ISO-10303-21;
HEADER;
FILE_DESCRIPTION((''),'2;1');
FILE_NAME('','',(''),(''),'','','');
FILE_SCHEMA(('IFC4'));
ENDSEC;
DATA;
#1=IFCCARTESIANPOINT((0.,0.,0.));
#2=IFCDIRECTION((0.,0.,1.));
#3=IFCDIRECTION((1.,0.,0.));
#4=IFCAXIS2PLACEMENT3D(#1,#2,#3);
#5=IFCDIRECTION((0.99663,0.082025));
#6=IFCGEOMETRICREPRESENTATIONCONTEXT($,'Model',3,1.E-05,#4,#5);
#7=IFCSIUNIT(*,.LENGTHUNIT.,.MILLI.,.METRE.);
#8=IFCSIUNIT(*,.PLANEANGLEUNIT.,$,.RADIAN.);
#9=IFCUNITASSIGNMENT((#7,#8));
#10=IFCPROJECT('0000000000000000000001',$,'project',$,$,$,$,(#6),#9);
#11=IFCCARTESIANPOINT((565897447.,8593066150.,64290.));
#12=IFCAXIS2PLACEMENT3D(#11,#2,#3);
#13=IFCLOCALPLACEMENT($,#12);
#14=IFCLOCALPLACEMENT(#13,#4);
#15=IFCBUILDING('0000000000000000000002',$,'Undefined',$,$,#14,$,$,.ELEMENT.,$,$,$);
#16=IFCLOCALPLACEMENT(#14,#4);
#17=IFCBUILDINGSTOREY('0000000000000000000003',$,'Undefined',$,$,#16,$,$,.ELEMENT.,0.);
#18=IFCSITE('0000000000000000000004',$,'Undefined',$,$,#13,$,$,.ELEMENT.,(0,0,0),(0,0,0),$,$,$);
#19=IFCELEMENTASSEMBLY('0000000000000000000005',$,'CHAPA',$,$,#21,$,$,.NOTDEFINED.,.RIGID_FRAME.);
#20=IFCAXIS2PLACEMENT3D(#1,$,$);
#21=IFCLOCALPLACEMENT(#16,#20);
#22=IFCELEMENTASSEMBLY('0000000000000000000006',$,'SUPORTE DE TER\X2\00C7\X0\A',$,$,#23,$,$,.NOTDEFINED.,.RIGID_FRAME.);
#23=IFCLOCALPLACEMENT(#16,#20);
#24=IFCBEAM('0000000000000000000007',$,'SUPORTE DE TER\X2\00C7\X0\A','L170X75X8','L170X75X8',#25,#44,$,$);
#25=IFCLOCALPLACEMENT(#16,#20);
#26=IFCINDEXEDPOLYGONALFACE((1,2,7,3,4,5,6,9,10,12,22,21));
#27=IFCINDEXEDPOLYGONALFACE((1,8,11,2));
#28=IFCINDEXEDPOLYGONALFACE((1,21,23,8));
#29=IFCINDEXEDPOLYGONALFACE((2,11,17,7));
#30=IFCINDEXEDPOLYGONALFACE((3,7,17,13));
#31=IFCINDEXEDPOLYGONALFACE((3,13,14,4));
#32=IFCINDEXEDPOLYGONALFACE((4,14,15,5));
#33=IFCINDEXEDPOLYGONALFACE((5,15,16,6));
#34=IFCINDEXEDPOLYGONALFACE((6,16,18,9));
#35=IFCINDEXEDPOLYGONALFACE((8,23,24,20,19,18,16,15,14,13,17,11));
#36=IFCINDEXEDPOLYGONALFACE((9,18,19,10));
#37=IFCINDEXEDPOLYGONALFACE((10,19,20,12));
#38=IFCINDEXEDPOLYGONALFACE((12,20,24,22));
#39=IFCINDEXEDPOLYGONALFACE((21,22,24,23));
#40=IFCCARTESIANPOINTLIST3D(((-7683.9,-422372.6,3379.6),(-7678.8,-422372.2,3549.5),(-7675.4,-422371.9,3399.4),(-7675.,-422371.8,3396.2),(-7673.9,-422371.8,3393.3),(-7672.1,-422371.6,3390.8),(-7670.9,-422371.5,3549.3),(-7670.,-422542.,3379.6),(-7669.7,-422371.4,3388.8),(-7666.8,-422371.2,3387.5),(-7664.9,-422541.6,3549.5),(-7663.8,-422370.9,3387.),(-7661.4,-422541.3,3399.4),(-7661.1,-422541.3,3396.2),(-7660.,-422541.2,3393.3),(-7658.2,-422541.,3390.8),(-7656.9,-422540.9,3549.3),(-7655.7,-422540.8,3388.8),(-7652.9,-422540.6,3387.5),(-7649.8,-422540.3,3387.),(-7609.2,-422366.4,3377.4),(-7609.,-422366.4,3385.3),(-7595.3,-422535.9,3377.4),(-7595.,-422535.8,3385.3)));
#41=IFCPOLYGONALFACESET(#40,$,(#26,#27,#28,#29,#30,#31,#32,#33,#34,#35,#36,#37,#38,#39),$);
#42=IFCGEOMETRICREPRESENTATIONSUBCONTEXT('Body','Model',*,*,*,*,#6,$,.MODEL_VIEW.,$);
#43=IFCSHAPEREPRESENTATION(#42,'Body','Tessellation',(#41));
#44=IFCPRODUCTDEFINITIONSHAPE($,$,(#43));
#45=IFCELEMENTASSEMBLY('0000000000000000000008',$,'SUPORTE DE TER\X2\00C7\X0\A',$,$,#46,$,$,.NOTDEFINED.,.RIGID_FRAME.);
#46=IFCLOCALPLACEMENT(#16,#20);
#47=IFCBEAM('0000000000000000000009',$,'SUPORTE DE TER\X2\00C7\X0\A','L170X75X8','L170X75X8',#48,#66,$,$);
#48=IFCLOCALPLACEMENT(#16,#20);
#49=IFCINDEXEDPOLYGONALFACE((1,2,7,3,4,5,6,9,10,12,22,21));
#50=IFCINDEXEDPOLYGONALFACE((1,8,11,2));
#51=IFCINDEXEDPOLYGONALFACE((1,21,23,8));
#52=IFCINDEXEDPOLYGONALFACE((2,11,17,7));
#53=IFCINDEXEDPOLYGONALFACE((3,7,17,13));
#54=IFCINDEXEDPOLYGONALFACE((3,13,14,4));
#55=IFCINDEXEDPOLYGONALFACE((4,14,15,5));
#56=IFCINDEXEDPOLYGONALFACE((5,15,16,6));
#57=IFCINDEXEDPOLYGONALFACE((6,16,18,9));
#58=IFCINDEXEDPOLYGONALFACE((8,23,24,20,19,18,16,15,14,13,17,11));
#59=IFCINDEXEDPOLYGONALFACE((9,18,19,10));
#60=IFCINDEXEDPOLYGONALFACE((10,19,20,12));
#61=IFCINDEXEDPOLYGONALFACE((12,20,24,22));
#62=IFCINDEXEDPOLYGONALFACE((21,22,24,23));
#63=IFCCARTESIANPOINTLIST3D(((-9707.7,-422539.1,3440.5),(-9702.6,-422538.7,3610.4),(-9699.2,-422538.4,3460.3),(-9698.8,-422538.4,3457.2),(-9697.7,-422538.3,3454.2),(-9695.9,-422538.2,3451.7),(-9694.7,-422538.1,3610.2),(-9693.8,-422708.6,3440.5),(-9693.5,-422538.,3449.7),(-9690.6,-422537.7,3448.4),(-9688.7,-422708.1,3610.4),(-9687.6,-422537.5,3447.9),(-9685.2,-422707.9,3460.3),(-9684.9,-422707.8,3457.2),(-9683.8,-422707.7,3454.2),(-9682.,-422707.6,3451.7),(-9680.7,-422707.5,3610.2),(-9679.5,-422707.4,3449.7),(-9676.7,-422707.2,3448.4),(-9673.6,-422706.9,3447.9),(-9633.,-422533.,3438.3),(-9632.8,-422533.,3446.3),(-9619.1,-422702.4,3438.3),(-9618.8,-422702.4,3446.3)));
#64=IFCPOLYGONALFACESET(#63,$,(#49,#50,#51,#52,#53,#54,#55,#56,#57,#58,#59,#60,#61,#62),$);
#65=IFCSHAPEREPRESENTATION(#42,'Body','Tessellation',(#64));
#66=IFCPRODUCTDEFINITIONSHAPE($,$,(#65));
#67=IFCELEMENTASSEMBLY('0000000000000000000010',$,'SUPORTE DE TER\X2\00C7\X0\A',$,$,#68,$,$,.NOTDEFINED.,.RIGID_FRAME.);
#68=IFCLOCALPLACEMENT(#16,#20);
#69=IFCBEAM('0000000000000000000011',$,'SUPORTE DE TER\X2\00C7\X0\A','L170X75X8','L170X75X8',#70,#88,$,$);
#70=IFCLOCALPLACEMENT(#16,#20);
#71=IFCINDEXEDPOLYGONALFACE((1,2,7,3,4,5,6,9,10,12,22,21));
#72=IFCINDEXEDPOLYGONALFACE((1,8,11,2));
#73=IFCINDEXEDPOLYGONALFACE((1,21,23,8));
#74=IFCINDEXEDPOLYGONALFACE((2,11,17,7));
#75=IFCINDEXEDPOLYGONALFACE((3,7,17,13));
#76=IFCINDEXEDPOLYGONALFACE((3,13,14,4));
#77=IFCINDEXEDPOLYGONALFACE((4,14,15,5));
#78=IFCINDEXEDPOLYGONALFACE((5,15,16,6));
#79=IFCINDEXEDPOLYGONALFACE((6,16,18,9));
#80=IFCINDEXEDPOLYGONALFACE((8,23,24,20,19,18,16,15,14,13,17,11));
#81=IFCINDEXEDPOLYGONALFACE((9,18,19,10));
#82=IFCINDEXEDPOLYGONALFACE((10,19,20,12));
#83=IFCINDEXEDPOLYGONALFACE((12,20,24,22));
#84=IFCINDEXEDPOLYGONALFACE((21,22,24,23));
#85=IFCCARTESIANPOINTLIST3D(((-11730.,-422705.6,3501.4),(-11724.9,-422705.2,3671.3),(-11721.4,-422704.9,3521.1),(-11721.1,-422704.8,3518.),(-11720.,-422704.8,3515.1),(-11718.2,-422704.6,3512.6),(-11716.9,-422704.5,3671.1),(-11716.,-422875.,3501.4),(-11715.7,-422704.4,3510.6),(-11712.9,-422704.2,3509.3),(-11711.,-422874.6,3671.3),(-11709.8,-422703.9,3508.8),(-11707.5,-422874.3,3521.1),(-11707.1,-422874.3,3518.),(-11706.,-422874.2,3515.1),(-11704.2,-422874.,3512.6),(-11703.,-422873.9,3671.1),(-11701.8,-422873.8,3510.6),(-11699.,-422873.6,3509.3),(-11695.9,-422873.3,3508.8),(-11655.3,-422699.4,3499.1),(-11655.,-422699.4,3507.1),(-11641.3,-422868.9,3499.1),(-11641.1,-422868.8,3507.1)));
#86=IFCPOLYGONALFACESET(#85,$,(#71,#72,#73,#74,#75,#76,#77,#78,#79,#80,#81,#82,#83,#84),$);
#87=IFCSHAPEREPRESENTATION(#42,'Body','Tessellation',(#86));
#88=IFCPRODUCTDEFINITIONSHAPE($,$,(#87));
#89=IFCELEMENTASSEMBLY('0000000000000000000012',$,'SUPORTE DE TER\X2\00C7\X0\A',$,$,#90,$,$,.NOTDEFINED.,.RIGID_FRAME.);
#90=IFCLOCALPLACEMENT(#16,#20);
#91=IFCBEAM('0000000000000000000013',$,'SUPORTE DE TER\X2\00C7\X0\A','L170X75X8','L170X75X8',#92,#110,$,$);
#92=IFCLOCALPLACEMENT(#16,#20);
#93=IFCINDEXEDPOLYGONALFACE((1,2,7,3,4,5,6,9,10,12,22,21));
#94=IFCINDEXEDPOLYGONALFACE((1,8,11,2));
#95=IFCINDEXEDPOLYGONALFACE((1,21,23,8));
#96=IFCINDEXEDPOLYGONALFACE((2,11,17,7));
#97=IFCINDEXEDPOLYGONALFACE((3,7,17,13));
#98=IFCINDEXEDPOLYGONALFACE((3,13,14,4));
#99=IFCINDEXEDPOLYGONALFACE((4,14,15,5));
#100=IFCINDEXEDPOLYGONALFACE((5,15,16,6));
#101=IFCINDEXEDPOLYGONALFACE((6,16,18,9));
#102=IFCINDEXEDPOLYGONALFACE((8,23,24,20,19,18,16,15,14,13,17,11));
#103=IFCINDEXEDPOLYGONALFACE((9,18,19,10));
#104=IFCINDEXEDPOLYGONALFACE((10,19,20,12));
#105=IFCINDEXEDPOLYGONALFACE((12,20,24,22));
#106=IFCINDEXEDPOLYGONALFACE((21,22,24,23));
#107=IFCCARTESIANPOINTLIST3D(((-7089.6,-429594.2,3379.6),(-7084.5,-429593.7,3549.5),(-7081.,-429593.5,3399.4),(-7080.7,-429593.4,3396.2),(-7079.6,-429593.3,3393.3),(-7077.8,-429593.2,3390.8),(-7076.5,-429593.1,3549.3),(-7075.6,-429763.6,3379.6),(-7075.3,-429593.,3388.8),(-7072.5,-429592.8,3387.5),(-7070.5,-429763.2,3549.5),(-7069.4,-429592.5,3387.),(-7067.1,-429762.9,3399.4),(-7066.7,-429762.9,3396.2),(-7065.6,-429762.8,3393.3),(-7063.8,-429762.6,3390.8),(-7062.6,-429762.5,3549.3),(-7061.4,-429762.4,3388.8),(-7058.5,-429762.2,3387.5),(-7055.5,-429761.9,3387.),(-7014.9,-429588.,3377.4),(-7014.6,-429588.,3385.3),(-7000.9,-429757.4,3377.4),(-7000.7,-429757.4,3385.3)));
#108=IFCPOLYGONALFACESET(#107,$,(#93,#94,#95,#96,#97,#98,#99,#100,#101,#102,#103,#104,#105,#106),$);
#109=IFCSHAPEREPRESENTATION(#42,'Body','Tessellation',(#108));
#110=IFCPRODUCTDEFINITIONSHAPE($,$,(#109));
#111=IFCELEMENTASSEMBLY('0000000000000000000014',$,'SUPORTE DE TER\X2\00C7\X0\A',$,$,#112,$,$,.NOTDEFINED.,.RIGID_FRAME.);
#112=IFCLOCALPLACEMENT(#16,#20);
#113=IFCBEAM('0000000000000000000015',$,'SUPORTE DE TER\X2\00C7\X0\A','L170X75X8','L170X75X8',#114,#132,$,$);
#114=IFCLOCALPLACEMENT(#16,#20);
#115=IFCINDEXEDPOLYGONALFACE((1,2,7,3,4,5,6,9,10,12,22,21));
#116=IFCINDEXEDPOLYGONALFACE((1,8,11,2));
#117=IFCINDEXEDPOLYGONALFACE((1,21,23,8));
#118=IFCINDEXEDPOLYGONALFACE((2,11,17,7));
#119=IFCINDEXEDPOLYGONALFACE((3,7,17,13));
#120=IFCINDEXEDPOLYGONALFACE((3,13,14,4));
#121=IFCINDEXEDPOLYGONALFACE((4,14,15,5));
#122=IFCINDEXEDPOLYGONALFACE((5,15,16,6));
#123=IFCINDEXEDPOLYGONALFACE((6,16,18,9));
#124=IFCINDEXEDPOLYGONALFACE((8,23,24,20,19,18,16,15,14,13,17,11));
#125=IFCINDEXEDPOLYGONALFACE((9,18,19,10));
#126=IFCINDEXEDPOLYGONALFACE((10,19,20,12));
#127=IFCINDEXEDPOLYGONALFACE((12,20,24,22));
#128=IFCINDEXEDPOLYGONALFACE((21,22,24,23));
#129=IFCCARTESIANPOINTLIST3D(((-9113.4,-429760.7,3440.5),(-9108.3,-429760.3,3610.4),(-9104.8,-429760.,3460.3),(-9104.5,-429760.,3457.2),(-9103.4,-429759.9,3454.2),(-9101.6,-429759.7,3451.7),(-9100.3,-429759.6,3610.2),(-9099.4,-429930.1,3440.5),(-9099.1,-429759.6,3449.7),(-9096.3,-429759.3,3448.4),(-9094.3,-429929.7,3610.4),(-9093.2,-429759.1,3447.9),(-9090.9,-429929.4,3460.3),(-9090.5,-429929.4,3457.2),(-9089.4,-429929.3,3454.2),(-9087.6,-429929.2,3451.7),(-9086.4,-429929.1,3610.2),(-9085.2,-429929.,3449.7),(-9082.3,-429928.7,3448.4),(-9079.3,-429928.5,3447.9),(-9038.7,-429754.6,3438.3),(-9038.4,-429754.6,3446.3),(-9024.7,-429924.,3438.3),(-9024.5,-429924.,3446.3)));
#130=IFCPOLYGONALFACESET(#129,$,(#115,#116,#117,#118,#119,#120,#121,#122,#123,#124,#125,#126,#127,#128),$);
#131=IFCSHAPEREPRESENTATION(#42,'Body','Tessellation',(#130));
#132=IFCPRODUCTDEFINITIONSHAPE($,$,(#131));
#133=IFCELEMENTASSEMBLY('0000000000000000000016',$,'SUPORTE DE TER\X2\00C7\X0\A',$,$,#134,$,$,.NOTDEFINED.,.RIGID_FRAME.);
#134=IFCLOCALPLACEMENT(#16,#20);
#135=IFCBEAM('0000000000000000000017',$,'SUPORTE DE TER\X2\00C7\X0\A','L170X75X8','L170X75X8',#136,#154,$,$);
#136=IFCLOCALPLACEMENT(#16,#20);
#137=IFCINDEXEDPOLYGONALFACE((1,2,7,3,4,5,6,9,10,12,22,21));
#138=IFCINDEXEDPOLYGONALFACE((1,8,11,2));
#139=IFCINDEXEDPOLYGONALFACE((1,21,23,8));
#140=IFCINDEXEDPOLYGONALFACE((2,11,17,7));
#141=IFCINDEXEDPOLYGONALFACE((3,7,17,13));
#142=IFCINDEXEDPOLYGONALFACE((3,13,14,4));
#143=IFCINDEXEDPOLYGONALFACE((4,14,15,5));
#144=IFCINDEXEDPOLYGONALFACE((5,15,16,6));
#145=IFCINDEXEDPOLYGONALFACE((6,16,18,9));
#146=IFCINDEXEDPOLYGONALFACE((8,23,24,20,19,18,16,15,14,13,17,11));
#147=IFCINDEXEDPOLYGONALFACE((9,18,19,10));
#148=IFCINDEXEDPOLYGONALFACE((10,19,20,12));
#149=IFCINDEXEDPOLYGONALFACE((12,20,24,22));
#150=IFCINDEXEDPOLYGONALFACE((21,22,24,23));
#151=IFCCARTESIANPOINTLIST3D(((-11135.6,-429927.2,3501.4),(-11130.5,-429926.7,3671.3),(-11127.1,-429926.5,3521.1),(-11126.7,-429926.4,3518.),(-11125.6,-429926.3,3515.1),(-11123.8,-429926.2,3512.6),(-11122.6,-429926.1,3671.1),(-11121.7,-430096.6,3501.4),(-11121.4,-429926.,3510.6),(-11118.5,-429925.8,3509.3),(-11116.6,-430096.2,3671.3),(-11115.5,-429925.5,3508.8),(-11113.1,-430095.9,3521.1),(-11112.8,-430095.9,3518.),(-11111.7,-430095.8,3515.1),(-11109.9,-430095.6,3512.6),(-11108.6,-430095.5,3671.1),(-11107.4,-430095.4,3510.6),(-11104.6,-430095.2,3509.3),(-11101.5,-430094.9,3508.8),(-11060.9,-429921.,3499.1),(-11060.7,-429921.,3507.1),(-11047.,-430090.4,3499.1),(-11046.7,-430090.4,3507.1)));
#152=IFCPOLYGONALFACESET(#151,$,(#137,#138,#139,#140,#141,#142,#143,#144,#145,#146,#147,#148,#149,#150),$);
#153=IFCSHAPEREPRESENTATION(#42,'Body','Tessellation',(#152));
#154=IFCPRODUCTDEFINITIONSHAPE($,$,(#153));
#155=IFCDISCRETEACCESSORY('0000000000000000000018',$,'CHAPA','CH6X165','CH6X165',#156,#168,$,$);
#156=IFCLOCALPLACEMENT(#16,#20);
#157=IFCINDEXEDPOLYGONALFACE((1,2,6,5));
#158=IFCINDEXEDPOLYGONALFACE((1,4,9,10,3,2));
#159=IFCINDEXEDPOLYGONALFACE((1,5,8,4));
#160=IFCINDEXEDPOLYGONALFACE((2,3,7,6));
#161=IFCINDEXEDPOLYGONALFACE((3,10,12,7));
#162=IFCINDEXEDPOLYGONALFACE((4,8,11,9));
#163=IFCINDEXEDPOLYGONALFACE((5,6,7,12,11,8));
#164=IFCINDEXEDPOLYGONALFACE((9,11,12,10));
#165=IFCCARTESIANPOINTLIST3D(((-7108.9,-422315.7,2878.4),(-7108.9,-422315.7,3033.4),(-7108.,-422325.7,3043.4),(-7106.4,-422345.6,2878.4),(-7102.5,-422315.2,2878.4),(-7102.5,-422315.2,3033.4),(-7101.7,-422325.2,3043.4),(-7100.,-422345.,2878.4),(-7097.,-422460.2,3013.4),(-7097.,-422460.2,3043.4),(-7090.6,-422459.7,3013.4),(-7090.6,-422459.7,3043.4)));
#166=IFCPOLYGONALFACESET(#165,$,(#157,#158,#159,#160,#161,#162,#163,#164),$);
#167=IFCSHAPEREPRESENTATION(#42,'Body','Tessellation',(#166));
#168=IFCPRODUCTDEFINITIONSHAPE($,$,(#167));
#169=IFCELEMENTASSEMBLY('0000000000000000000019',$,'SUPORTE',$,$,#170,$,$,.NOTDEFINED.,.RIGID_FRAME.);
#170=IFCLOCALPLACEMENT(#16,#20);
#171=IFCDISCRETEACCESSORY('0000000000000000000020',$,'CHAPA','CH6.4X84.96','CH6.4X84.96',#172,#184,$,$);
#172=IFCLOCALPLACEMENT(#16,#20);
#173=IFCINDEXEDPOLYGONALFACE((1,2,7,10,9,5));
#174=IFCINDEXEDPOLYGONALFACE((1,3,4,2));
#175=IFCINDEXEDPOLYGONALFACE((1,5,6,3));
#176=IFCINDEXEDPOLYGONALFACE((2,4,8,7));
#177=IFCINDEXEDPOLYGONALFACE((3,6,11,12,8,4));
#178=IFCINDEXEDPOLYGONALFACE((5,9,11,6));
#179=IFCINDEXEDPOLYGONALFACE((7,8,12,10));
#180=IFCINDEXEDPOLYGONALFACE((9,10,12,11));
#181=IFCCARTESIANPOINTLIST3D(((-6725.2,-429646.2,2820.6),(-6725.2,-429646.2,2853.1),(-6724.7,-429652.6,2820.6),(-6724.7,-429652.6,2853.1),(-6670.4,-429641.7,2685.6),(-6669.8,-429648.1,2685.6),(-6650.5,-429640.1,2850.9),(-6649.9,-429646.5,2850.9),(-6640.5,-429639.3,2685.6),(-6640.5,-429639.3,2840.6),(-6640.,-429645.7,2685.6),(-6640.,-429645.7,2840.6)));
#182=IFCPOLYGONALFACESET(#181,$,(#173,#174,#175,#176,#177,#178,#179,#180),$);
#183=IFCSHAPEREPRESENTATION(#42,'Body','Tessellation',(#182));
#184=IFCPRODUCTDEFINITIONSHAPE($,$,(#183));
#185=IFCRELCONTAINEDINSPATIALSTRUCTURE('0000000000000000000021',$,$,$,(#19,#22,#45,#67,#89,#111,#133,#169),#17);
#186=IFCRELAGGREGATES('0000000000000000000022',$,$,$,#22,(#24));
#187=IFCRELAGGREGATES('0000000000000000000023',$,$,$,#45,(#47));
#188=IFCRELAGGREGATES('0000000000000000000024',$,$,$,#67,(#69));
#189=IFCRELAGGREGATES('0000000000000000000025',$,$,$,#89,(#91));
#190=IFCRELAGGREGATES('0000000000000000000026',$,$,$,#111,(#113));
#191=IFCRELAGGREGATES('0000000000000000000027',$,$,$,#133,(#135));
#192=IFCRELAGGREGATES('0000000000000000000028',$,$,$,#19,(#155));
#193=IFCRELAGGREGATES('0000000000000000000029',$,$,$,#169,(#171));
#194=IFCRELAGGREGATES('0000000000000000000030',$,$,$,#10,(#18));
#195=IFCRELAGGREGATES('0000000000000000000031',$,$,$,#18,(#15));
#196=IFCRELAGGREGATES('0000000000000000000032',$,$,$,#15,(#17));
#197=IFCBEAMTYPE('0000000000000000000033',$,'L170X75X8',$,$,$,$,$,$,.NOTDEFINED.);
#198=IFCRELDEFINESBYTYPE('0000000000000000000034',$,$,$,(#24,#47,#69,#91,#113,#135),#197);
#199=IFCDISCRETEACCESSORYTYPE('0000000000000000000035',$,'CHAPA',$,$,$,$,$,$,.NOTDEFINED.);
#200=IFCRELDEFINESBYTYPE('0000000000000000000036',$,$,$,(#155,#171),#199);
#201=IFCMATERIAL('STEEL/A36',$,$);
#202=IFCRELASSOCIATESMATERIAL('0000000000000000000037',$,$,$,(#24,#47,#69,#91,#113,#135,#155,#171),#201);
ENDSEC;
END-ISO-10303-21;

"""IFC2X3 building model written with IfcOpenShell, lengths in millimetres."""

from ifc_helpers import new_model, si_unit, direction, frame, origin_with_axes, origin_2d_with_axis, place, context, subcontext, project, spatial, polyline, l_section, outline, extrude, material, type_object, element, aggregate, save


model = new_model("IFC2X3")

# Units and contexts
model_context = context("Model", 3, precision=1e-05, world=origin_with_axes(), true_north=direction((0.99663, 0.082025)))
body_context = subcontext(model_context, "Body", "Model", "MODEL_VIEW")
ifc_project = project(units=[si_unit("LENGTHUNIT", "METRE", prefix="MILLI"), si_unit("PLANEANGLEUNIT", "RADIAN")], contexts=[model_context])

# Site, building, storey
site_placement = place(None, frame((565897447.0, 8593066150.0, 64290.0), z_axis=(0.0, 0.0, 1.0), x_axis=(1.0, 0.0, 0.0)))
site = spatial("IfcSite", under=ifc_project, at=site_placement, Name="Undefined", CompositionType="ELEMENT", RefLatitude=(0, 0, 0), RefLongitude=(0, 0, 0))
building_placement = place(site_placement, origin_with_axes())
building = spatial("IfcBuilding", under=site, at=building_placement, Name="Undefined", CompositionType="ELEMENT")
storey_placement = place(building_placement, origin_with_axes())
storey = spatial("IfcBuildingStorey", under=building, at=storey_placement, Name="Undefined", CompositionType="ELEMENT", Elevation=0.0)

# Element assemblies, beams
assembly_1_placement = place(storey_placement, origin_with_axes())
assembly_1 = element("IfcElementAssembly", 1, at=assembly_1_placement, inside=storey, Name="CHAPA", AssemblyPlace="NOTDEFINED", PredefinedType="RIGID_FRAME")
ifc_material_1 = material(Name="STEEL/A36")
assembly_2_placement = place(storey_placement, origin_with_axes())
assembly_2 = element("IfcElementAssembly", 2, at=assembly_2_placement, inside=storey, Name="SUPORTE DE TERÇA", AssemblyPlace="NOTDEFINED", PredefinedType="RIGID_FRAME")
beam_type_1 = type_object("IfcBeamType", Name="L170X75X8", PredefinedType="NOTDEFINED")
beam_1_placement = place(assembly_2_placement, frame((-7630.1, -422538.7, 3463.4), z_axis=(0.029885, 0.00246, 0.99955), x_axis=(-0.082025, 0.99663, 0.0)))
beam_1 = element("IfcBeam", 3, at=beam_1_placement, type_object=beam_type_1, material=ifc_material_1, Name="SUPORTE DE TERÇA", Description="L170X75X8", ObjectType="L170X75X8", context=body_context, shape_type="SweptSolid", body=[
    extrude(l_section(Depth=170.0, Width=75.0, Thickness=8.0, FilletRadius=12.0, at=origin_2d_with_axis()), frame((170.0, 0.0, 0.0), z_axis=(-1.0, 0.0, 0.0), x_axis=(0.0, -1.0, 0.0)), (0.0, 0.0, 1.0), 170.0),
])
aggregate(assembly_2, [beam_1])
assembly_3_placement = place(storey_placement, origin_with_axes())
assembly_3 = element("IfcElementAssembly", 4, at=assembly_3_placement, inside=storey, Name="SUPORTE DE TERÇA", AssemblyPlace="NOTDEFINED", PredefinedType="RIGID_FRAME")
beam_2_placement = place(assembly_3_placement, frame((-9653.9, -422705.3, 3524.4), z_axis=(0.029885, 0.00246, 0.99955), x_axis=(-0.082025, 0.99663, 0.0)))
beam_2 = element("IfcBeam", 5, at=beam_2_placement, type_object=beam_type_1, material=ifc_material_1, Name="SUPORTE DE TERÇA", Description="L170X75X8", ObjectType="L170X75X8", context=body_context, shape_type="SweptSolid", body=[
    extrude(l_section(Depth=170.0, Width=75.0, Thickness=8.0, FilletRadius=12.0, at=origin_2d_with_axis()), frame((170.0, 0.0, 0.0), z_axis=(-1.0, 0.0, 0.0), x_axis=(0.0, -1.0, 0.0)), (0.0, 0.0, 1.0), 170.0),
])
aggregate(assembly_3, [beam_2])
assembly_4_placement = place(storey_placement, origin_with_axes())
assembly_4 = element("IfcElementAssembly", 6, at=assembly_4_placement, inside=storey, Name="SUPORTE DE TERÇA", AssemblyPlace="NOTDEFINED", PredefinedType="RIGID_FRAME")
beam_3_placement = place(assembly_4_placement, frame((-11676.1, -422871.7, 3585.2), z_axis=(0.029885, 0.00246, 0.99955), x_axis=(-0.082025, 0.99663, 0.0)))
beam_3 = element("IfcBeam", 7, at=beam_3_placement, type_object=beam_type_1, material=ifc_material_1, Name="SUPORTE DE TERÇA", Description="L170X75X8", ObjectType="L170X75X8", context=body_context, shape_type="SweptSolid", body=[
    extrude(l_section(Depth=170.0, Width=75.0, Thickness=8.0, FilletRadius=12.0, at=origin_2d_with_axis()), frame((170.0, 0.0, 0.0), z_axis=(-1.0, 0.0, 0.0), x_axis=(0.0, -1.0, 0.0)), (0.0, 0.0, 1.0), 170.0),
])
aggregate(assembly_4, [beam_3])
assembly_5_placement = place(storey_placement, origin_with_axes())
assembly_5 = element("IfcElementAssembly", 8, at=assembly_5_placement, inside=storey, Name="SUPORTE DE TERÇA", AssemblyPlace="NOTDEFINED", PredefinedType="RIGID_FRAME")
beam_4_placement = place(assembly_5_placement, frame((-7035.7, -429760.3, 3463.4), z_axis=(0.029885, 0.00246, 0.99955), x_axis=(-0.082025, 0.99663, 0.0)))
beam_4 = element("IfcBeam", 9, at=beam_4_placement, type_object=beam_type_1, material=ifc_material_1, Name="SUPORTE DE TERÇA", Description="L170X75X8", ObjectType="L170X75X8", context=body_context, shape_type="SweptSolid", body=[
    extrude(l_section(Depth=170.0, Width=75.0, Thickness=8.0, FilletRadius=12.0, at=origin_2d_with_axis()), frame((170.0, 0.0, 0.0), z_axis=(-1.0, 0.0, 0.0), x_axis=(0.0, -1.0, 0.0)), (0.0, 0.0, 1.0), 170.0),
])
aggregate(assembly_5, [beam_4])
assembly_6_placement = place(storey_placement, origin_with_axes())
assembly_6 = element("IfcElementAssembly", 10, at=assembly_6_placement, inside=storey, Name="SUPORTE DE TERÇA", AssemblyPlace="NOTDEFINED", PredefinedType="RIGID_FRAME")
beam_5_placement = place(assembly_6_placement, frame((-9059.5, -429926.9, 3524.4), z_axis=(0.029885, 0.00246, 0.99955), x_axis=(-0.082025, 0.99663, 0.0)))
beam_5 = element("IfcBeam", 11, at=beam_5_placement, type_object=beam_type_1, material=ifc_material_1, Name="SUPORTE DE TERÇA", Description="L170X75X8", ObjectType="L170X75X8", context=body_context, shape_type="SweptSolid", body=[
    extrude(l_section(Depth=170.0, Width=75.0, Thickness=8.0, FilletRadius=12.0, at=origin_2d_with_axis()), frame((170.0, 0.0, 0.0), z_axis=(-1.0, 0.0, 0.0), x_axis=(0.0, -1.0, 0.0)), (0.0, 0.0, 1.0), 170.0),
])
aggregate(assembly_6, [beam_5])
assembly_7_placement = place(storey_placement, origin_with_axes())
assembly_7 = element("IfcElementAssembly", 12, at=assembly_7_placement, inside=storey, Name="SUPORTE DE TERÇA", AssemblyPlace="NOTDEFINED", PredefinedType="RIGID_FRAME")
beam_6_placement = place(assembly_7_placement, frame((-11081.8, -430093.3, 3585.2), z_axis=(0.029885, 0.00246, 0.99955), x_axis=(-0.082025, 0.99663, 0.0)))
beam_6 = element("IfcBeam", 13, at=beam_6_placement, type_object=beam_type_1, material=ifc_material_1, Name="SUPORTE DE TERÇA", Description="L170X75X8", ObjectType="L170X75X8", context=body_context, shape_type="SweptSolid", body=[
    extrude(l_section(Depth=170.0, Width=75.0, Thickness=8.0, FilletRadius=12.0, at=origin_2d_with_axis()), frame((170.0, 0.0, 0.0), z_axis=(-1.0, 0.0, 0.0), x_axis=(0.0, -1.0, 0.0)), (0.0, 0.0, 1.0), 170.0),
])
aggregate(assembly_7, [beam_6])

# Discrete accessory
discrete_accessory_type_1 = type_object("IfcDiscreteAccessoryType", Name="CHAPA")
discrete_accessory_1_placement = place(assembly_1_placement, frame((-7105.7, -422315.5, 3043.4), z_axis=(-0.99663, -0.082025, -0.000004), x_axis=(0.000004, 0.0, -1.0)))
discrete_accessory_1 = element("IfcDiscreteAccessory", 14, at=discrete_accessory_1_placement, type_object=discrete_accessory_type_1, material=ifc_material_1, Name="CHAPA", Description="CH6X165", ObjectType="CH6X165", context=body_context, shape_type="SweptSolid", body=[
    extrude(outline(polyline([(0.0, 10.0), (10.0, 0.0), (165.0, 0.0), (165.0, 30.0), (30.0, 145.0), (0.0, 145.0), (0.0, 10.0)])), frame((0.0, 0.0, -3.2), z_axis=(0.0, 0.0, 1.0), x_axis=(1.0, 0.0, 0.0)), (0.0, 0.0, 1.0), 6.4),
])
aggregate(assembly_1, [discrete_accessory_1])

# Element assembly, discrete accessory
assembly_8_placement = place(storey_placement, origin_with_axes())
assembly_8 = element("IfcElementAssembly", 15, at=assembly_8_placement, inside=storey, Name="SUPORTE", AssemblyPlace="NOTDEFINED", PredefinedType="RIGID_FRAME")
discrete_accessory_2_placement = place(assembly_8_placement, frame((-6640.2, -429642.5, 2850.6), z_axis=(-0.082025, 0.99663, 0.0), x_axis=(0.0, 0.0, -1.0)))
discrete_accessory_2 = element("IfcDiscreteAccessory", 16, at=discrete_accessory_2_placement, type_object=discrete_accessory_type_1, material=ifc_material_1, Name="CHAPA", Description="CH6.4X84.96", ObjectType="CH6.4X84.96", context=body_context, shape_type="SweptSolid", body=[
    extrude(outline(polyline([(-0.3, 10.0), (10.0, 0.0), (165.0, 0.0), (165.0, 30.0), (30.0, 85.0), (-2.5, 85.0), (-0.3, 10.0)])), frame((0.0, 0.0, -3.2), z_axis=(0.0, 0.0, 1.0), x_axis=(1.0, 0.0, 0.0)), (0.0, 0.0, 1.0), 6.4),
])
aggregate(assembly_8, [discrete_accessory_2])

save(model, "model.ifc")
